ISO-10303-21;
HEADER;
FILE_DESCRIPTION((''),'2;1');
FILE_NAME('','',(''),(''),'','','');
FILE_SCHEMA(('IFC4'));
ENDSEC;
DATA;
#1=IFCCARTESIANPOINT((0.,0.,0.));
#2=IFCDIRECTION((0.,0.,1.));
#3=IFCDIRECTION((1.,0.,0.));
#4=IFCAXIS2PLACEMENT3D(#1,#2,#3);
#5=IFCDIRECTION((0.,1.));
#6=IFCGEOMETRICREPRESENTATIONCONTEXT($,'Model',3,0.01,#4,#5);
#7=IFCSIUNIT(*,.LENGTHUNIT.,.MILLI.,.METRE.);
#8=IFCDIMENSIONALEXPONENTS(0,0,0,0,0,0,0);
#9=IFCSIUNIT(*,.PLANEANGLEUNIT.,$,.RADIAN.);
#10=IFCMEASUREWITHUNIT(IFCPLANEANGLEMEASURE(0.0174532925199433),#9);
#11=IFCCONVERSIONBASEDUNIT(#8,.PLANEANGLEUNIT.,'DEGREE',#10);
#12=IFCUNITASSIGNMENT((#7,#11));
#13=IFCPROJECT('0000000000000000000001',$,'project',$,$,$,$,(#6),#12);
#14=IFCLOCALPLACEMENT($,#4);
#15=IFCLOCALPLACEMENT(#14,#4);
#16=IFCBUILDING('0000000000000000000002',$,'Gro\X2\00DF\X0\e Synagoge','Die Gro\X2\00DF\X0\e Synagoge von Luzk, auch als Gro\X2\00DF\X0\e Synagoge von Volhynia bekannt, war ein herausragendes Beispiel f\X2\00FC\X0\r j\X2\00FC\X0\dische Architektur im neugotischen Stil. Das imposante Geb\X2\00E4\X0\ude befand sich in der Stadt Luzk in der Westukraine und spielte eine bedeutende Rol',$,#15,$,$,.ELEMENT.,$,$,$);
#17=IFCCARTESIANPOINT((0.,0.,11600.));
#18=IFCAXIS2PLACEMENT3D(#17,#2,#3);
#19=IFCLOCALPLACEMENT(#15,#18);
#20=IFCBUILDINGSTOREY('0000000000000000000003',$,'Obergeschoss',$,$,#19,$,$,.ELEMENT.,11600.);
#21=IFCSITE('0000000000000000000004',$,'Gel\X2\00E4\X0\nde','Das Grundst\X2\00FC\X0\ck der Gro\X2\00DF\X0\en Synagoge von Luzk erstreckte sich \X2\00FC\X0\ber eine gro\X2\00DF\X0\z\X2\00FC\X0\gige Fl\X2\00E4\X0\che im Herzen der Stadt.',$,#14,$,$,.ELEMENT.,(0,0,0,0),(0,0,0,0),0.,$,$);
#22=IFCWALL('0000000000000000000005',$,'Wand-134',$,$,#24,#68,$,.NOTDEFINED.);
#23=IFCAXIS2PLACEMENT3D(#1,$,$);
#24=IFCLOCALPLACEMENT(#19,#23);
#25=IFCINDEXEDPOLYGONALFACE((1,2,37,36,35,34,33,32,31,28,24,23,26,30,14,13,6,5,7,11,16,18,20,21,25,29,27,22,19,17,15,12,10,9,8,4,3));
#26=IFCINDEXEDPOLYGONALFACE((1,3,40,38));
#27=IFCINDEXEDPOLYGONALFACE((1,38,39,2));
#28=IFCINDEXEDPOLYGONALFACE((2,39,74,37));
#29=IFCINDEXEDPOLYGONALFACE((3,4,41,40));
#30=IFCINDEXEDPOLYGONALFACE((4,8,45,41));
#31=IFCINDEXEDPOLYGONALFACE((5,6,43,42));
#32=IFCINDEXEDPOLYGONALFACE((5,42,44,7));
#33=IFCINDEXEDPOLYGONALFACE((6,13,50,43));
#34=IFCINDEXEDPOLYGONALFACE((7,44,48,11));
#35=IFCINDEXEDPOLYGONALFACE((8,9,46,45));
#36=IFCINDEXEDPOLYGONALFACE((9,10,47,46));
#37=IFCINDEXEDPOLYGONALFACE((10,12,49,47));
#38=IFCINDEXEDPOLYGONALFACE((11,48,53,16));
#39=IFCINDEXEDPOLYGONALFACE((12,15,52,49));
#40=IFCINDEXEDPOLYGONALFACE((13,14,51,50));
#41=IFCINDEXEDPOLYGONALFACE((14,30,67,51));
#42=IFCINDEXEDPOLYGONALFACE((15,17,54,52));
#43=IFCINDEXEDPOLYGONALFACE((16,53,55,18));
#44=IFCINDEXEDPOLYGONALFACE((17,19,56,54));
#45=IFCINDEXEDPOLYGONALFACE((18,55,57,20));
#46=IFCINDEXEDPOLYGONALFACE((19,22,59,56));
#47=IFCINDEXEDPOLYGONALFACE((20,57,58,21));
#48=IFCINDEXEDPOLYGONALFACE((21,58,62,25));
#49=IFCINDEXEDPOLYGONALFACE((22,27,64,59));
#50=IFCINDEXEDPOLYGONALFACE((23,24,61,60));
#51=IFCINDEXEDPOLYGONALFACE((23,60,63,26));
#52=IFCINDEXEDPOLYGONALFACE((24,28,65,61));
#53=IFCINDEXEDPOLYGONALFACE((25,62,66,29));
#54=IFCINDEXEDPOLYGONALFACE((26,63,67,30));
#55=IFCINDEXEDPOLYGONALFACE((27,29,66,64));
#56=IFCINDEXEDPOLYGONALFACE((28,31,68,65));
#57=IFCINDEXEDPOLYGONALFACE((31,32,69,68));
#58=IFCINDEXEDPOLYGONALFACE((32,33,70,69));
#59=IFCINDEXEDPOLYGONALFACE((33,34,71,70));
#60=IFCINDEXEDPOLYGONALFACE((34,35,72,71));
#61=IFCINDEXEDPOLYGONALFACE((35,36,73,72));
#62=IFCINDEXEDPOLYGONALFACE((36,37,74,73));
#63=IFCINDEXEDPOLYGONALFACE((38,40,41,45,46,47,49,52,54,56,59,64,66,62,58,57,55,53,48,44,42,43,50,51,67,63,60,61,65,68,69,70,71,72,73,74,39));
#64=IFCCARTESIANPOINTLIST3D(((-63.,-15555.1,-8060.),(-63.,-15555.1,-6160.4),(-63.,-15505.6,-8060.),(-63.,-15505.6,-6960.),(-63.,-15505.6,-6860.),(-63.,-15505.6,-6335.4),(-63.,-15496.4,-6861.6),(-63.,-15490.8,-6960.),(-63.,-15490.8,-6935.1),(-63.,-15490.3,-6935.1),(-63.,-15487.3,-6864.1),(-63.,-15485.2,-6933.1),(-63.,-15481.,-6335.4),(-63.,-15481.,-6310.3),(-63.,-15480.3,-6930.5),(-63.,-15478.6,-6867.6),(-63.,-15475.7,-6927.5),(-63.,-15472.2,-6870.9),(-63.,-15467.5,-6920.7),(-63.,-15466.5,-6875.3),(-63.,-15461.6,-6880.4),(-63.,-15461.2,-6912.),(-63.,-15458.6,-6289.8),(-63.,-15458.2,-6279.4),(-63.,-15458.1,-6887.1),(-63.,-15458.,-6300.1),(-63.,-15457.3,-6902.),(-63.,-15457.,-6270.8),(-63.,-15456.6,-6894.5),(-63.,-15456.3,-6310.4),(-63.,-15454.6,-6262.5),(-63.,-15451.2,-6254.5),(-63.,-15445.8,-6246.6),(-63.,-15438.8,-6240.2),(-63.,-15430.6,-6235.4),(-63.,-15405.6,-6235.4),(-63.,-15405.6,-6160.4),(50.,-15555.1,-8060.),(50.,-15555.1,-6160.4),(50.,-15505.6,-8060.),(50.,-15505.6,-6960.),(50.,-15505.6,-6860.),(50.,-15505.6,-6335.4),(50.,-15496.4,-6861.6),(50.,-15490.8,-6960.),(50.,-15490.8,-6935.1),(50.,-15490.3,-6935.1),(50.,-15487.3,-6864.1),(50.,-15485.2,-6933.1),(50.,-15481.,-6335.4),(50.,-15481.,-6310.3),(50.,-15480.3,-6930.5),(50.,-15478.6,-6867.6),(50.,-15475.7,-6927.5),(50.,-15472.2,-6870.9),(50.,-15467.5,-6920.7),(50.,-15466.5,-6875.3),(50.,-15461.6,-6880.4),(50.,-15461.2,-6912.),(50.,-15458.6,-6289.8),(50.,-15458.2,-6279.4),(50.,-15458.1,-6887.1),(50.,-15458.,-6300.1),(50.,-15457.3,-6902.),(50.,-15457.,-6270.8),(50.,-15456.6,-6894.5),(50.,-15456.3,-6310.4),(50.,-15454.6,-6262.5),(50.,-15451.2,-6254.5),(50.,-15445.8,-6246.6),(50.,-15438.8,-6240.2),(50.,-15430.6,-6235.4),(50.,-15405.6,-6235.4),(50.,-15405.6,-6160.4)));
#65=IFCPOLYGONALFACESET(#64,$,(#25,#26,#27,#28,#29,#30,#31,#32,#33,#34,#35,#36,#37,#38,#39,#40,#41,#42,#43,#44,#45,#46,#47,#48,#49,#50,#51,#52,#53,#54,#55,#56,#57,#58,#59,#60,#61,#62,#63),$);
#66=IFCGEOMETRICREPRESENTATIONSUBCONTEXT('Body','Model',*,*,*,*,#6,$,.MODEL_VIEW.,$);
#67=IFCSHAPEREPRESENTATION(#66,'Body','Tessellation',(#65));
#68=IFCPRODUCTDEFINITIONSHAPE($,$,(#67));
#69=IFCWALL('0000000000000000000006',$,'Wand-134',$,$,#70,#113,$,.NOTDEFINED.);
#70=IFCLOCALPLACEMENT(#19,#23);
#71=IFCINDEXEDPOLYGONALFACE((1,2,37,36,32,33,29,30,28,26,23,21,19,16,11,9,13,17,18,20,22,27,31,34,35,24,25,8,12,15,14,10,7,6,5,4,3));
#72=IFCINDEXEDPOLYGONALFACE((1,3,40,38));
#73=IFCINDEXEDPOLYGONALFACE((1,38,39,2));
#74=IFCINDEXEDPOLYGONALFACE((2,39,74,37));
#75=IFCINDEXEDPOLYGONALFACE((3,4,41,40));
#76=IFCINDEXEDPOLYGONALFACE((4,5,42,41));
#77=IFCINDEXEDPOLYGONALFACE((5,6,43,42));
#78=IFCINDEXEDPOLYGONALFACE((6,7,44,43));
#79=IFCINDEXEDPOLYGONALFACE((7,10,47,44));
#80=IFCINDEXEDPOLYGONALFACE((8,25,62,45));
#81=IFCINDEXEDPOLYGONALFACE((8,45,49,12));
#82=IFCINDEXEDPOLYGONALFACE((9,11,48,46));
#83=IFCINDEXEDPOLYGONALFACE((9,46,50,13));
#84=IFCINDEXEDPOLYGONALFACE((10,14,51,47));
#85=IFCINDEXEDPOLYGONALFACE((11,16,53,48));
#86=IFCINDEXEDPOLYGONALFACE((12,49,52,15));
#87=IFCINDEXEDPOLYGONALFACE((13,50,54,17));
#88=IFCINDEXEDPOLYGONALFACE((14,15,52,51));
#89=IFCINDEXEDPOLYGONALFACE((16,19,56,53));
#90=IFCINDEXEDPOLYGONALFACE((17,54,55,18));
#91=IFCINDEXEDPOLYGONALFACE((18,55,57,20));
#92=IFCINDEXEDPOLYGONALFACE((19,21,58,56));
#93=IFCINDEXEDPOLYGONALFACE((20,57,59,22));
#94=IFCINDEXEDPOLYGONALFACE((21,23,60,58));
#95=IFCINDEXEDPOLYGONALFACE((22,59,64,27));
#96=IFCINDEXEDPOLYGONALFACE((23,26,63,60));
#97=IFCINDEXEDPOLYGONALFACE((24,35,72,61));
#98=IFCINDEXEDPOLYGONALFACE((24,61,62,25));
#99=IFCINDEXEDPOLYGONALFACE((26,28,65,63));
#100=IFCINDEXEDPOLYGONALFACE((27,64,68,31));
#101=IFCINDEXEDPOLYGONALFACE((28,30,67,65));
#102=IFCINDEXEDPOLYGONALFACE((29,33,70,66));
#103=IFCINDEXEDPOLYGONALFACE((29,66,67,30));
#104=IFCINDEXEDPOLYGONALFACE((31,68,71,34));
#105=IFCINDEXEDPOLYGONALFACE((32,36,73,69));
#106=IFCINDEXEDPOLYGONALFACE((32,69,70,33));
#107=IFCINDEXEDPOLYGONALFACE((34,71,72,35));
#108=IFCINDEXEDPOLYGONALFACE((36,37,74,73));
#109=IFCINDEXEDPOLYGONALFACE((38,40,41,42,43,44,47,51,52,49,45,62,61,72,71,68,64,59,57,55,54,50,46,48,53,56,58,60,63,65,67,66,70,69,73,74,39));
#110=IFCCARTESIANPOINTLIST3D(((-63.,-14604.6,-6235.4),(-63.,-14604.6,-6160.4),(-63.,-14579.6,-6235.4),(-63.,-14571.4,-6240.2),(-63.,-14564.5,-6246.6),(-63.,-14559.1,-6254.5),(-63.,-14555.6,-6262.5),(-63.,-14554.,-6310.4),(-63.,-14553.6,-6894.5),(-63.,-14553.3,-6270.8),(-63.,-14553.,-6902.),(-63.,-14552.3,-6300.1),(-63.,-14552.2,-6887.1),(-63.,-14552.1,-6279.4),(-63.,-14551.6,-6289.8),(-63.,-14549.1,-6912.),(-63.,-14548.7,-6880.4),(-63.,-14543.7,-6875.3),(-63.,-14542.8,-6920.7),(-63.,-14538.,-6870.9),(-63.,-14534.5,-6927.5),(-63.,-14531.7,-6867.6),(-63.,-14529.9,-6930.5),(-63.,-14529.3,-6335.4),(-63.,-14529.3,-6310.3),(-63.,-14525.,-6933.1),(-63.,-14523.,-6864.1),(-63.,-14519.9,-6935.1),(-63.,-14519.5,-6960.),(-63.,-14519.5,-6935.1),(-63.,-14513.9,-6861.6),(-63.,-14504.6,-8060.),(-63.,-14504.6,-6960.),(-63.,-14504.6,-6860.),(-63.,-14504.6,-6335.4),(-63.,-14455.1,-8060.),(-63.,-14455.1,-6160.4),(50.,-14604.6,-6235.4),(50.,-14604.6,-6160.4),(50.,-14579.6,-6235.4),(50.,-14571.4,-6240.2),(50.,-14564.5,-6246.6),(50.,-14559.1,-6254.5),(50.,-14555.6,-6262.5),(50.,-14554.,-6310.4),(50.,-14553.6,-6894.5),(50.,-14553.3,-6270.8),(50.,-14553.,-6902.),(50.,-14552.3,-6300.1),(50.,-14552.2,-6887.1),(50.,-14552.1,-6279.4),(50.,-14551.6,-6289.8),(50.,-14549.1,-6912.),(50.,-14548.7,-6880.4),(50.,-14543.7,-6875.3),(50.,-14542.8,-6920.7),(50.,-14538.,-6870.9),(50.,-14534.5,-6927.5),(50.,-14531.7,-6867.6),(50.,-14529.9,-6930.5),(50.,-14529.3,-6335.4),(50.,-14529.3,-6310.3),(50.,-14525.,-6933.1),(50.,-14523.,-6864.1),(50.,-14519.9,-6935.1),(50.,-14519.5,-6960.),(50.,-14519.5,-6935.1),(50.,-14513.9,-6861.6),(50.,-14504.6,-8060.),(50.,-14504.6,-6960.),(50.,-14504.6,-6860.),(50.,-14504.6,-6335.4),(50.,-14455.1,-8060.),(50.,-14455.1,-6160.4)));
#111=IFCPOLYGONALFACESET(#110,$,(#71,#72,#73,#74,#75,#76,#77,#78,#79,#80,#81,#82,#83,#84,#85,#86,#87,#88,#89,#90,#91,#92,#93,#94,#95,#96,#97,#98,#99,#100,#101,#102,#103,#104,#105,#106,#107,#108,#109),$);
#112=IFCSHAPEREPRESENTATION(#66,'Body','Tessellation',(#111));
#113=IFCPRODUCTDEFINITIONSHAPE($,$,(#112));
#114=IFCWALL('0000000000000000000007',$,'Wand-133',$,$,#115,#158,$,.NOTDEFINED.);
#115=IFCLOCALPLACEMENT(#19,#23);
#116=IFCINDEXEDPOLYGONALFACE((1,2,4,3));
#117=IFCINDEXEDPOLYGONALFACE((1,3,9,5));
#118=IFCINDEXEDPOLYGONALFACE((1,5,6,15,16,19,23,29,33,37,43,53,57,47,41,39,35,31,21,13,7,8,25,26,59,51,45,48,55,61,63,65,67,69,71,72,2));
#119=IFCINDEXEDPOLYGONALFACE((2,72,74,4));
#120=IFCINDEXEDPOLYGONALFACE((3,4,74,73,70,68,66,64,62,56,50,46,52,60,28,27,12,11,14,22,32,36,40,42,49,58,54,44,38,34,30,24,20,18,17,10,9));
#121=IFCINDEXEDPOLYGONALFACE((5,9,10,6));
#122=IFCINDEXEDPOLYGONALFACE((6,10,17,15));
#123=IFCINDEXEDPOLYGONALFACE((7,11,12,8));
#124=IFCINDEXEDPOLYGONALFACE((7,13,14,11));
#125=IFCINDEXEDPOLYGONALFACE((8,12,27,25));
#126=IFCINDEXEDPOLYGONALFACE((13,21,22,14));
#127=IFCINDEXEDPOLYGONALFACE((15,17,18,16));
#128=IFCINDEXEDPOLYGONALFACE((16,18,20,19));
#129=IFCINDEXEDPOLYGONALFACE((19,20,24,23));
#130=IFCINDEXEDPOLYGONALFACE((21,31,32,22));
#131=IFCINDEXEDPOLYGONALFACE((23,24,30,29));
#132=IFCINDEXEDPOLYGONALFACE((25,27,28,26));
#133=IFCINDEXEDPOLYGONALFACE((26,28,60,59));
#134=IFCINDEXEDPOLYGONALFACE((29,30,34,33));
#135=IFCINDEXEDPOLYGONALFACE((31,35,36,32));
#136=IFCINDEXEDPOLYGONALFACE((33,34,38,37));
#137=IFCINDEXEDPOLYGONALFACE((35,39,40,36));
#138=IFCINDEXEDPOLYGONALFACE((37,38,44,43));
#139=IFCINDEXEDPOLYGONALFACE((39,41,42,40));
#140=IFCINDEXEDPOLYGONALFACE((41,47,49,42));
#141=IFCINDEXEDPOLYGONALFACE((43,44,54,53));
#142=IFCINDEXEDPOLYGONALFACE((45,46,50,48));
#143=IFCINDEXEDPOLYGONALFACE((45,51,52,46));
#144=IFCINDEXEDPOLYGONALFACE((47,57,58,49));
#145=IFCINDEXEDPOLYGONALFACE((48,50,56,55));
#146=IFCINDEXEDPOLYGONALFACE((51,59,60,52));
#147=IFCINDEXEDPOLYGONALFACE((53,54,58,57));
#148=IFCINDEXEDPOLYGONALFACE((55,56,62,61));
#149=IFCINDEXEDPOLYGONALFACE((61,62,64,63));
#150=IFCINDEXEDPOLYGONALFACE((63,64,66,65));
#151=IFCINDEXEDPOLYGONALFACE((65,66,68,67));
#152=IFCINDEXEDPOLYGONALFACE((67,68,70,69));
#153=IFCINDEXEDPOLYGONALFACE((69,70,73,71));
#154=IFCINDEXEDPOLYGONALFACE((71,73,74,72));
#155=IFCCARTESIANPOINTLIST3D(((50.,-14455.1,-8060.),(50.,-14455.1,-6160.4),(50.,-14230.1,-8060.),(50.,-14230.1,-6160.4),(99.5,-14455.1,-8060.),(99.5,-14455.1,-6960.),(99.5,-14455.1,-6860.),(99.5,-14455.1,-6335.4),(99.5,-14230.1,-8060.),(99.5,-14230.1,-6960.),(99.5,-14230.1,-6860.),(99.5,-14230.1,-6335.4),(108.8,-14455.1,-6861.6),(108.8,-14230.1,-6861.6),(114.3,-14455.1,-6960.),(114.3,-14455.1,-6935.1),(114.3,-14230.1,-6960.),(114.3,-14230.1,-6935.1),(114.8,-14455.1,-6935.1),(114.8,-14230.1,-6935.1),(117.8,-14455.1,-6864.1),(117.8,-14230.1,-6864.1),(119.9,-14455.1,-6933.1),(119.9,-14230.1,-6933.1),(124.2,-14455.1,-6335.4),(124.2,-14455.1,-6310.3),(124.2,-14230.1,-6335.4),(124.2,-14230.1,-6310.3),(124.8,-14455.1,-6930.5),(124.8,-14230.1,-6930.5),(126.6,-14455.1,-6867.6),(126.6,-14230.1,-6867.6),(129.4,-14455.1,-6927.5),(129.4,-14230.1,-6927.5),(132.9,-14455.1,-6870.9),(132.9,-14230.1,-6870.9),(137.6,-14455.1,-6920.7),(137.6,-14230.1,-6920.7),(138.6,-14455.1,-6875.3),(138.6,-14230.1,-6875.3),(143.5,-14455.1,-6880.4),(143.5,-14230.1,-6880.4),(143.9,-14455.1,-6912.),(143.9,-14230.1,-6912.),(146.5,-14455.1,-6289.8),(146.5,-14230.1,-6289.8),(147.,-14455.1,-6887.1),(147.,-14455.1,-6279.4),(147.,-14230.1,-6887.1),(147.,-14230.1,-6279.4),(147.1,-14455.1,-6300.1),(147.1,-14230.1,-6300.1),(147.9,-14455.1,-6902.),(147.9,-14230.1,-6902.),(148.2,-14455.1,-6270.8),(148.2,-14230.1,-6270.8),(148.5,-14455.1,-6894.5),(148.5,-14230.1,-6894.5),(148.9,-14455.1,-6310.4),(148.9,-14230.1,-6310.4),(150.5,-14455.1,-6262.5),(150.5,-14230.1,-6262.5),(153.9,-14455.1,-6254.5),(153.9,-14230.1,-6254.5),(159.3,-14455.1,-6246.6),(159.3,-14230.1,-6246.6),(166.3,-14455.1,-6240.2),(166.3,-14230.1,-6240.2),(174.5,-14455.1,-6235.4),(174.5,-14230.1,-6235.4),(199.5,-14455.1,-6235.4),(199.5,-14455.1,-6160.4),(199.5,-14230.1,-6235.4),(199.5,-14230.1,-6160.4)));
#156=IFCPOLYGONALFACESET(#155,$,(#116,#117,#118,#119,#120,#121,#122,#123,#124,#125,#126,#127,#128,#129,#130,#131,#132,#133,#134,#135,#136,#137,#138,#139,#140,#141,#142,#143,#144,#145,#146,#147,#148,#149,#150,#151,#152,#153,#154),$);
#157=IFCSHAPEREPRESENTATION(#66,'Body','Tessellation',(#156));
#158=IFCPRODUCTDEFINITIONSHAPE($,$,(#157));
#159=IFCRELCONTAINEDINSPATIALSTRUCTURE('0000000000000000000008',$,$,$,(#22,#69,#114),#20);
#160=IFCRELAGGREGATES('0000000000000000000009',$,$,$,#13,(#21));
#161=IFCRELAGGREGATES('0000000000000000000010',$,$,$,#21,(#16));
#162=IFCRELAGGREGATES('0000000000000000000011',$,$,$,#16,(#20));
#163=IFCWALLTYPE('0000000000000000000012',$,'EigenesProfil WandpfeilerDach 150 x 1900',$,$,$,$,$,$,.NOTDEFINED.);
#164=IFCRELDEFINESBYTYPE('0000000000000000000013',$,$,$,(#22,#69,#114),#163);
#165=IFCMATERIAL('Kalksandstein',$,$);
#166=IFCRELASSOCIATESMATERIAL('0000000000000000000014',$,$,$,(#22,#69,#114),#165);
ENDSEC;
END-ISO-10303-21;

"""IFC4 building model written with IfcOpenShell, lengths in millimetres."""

from ifc_helpers import new_model, entity, si_unit, converted_unit, direction, frame, origin_with_axes, place, context, subcontext, project, spatial, line, arc, indexed_curve, outline, extrude, material, material_profile, profile_set, type_object, element, save


model = new_model("IFC4")

# Units and contexts
model_context = context("Model", 3, precision=0.01, world=origin_with_axes(), true_north=direction((0.0, 1.0)))
body_context = subcontext(model_context, "Body", "Model", "MODEL_VIEW")
ifc_project = project(units=[si_unit("LENGTHUNIT", "METRE", prefix="MILLI"), converted_unit("PLANEANGLEUNIT", "DEGREE", entity("IfcPlaneAngleMeasure", 0.0174532925199433), si_unit("PLANEANGLEUNIT", "RADIAN"), dimensions=[0, 0, 0, 0, 0, 0, 0])], contexts=[model_context])

# Site, building, storey
site_placement = place(None, origin_with_axes())
site = spatial("IfcSite", under=ifc_project, at=site_placement, Name="Gelände", Description="Das Grundstück der Großen Synagoge von Luzk erstreckte sich über eine großzügige Fläche im Herzen der Stadt.", CompositionType="ELEMENT", RefLatitude=(0, 0, 0, 0), RefLongitude=(0, 0, 0, 0), RefElevation=0.0)
building_placement = place(site_placement, origin_with_axes())
building = spatial("IfcBuilding", under=site, at=building_placement, Name="Große Synagoge", Description="Die Große Synagoge von Luzk, auch als Große Synagoge von Volhynia bekannt, war ein herausragendes Beispiel für jüdische Architektur im neugotischen Stil. Das imposante Gebäude befand sich in der Stadt Luzk in der Westukraine und spielte eine bedeutende Rol", CompositionType="ELEMENT")
storey_placement = place(building_placement, frame((0.0, 0.0, 11600.0), z_axis=(0.0, 0.0, 1.0), x_axis=(1.0, 0.0, 0.0)))
storey = spatial("IfcBuildingStorey", under=building, at=storey_placement, Name="Obergeschoss", CompositionType="ELEMENT", Elevation=11600.0)

# Walls
ifc_material_1 = material(Name="Kalksandstein")
ifc_material_profile = material_profile(ifc_material_1, outline(indexed_curve([(74.2, 1749.6), (98.9, 1749.6), (96.7, 1765.0), (97.0, 1780.5), (99.2, 1793.4), (103.9, 1805.5), (112.6, 1816.7), (124.5, 1824.6), (149.5, 1824.6), (149.5, 1899.6), (0.0, 1899.6), (0.0, 0.0), (49.5, 0.0), (49.5, 1100.0), (64.3, 1100.0), (64.3, 1124.9), (64.8, 1124.9), (72.4, 1128.1), (79.4, 1132.4), (91.1, 1143.4), (97.9, 1157.9), (98.0, 1169.2), (93.5, 1179.5), (85.8, 1187.0), (76.6, 1192.3), (63.3, 1197.2), (49.5, 1200.0), (49.5, 1724.6), (74.2, 1724.6)], segments=[line(1, 2), arc(2, 3, 4), arc(4, 5, 6), arc(6, 7, 8), line(8, 9, 10, 11, 12, 13, 14, 15, 16, 17), arc(17, 18, 19), arc(19, 20, 21), arc(21, 22, 23), arc(23, 24, 25), arc(25, 26, 27), line(27, 28, 29, 1)])), Name="Kalksandstein")
ifc_profile_set = profile_set([ifc_material_profile], Name="EigenesProfil WandpfeilerDach")
wall_type_1 = type_object("IfcWallType", Name="EigenesProfil WandpfeilerDach 150 x 1900", PredefinedType="NOTDEFINED")
wall_1_placement = place(storey_placement, frame((50.0, -15555.1, -8060.0), z_axis=(0.0, 0.0, 1.0), x_axis=(-1.0, 0.0, 0.0)))
element("IfcWall", 1, at=wall_1_placement, inside=storey, type_object=wall_type_1, material=ifc_profile_set, Name="Wand-134", PredefinedType="NOTDEFINED", context=body_context, shape_type="SweptSolid", body=[
    extrude(outline(indexed_curve([(74.2, 1749.6), (98.9, 1749.6), (96.7, 1765.0), (97.0, 1780.5), (99.2, 1793.4), (103.9, 1805.5), (112.6, 1816.7), (124.5, 1824.6), (149.5, 1824.6), (149.5, 1899.6), (0.0, 1899.6), (0.0, 0.0), (49.5, 0.0), (49.5, 1100.0), (64.3, 1100.0), (64.3, 1124.9), (64.8, 1124.9), (72.4, 1128.1), (79.4, 1132.4), (91.1, 1143.4), (97.9, 1157.9), (98.0, 1169.2), (93.5, 1179.5), (85.8, 1187.0), (76.6, 1192.3), (63.3, 1197.2), (49.5, 1200.0), (49.5, 1724.6), (74.2, 1724.6)], segments=[line(1, 2), arc(2, 3, 4), arc(4, 5, 6), arc(6, 7, 8), line(8, 9, 10, 11, 12, 13, 14, 15, 16, 17), arc(17, 18, 19), arc(19, 20, 21), arc(21, 22, 23), arc(23, 24, 25), arc(25, 26, 27), line(27, 28, 29, 1)])), frame((0.0, 0.0, 0.0), z_axis=(-1.0, 0.0, 0.0), x_axis=(0.0, -1.0, 0.0)), (0.0, 0.0, -1.0), 113.0),
])
wall_2_placement = place(storey_placement, frame((50.0, -14455.1, -8060.0), z_axis=(0.0, 0.0, 1.0), x_axis=(-1.0, 0.0, 0.0)))
element("IfcWall", 2, at=wall_2_placement, inside=storey, type_object=wall_type_1, material=ifc_profile_set, Name="Wand-134", PredefinedType="NOTDEFINED", context=body_context, shape_type="SweptSolid", body=[
    extrude(outline(indexed_curve([(74.2, 1749.6), (98.9, 1749.6), (96.7, 1765.0), (97.0, 1780.5), (99.2, 1793.4), (103.9, 1805.5), (112.6, 1816.7), (124.5, 1824.6), (149.5, 1824.6), (149.5, 1899.6), (0.0, 1899.6), (0.0, 0.0), (49.5, 0.0), (49.5, 1100.0), (64.3, 1100.0), (64.3, 1124.9), (64.8, 1124.9), (72.4, 1128.1), (79.4, 1132.4), (91.1, 1143.4), (97.9, 1157.9), (98.0, 1169.2), (93.5, 1179.5), (85.8, 1187.0), (76.6, 1192.3), (63.3, 1197.2), (49.5, 1200.0), (49.5, 1724.6), (74.2, 1724.6)], segments=[line(1, 2), arc(2, 3, 4), arc(4, 5, 6), arc(6, 7, 8), line(8, 9, 10, 11, 12, 13, 14, 15, 16, 17), arc(17, 18, 19), arc(19, 20, 21), arc(21, 22, 23), arc(23, 24, 25), arc(25, 26, 27), line(27, 28, 29, 1)])), frame((0.0, 0.0, 0.0), z_axis=(1.0, 0.0, 0.0), x_axis=(0.0, 1.0, 0.0)), (0.0, 0.0, 1.0), 113.0),
])
wall_3_placement = place(storey_placement, frame((50.0, -14230.1, -8060.0), z_axis=(0.0, 0.0, 1.0), x_axis=(0.0, -1.0, 0.0)))
element("IfcWall", 3, at=wall_3_placement, inside=storey, type_object=wall_type_1, material=ifc_profile_set, Name="Wand-133", PredefinedType="NOTDEFINED", context=body_context, shape_type="SweptSolid", body=[
    extrude(outline(indexed_curve([(74.2, 1749.6), (98.9, 1749.6), (96.7, 1765.0), (97.0, 1780.5), (99.2, 1793.4), (103.9, 1805.5), (112.6, 1816.7), (124.5, 1824.6), (149.5, 1824.6), (149.5, 1899.6), (0.0, 1899.6), (0.0, 0.0), (49.5, 0.0), (49.5, 1100.0), (64.3, 1100.0), (64.3, 1124.9), (64.8, 1124.9), (72.4, 1128.1), (79.4, 1132.4), (91.1, 1143.4), (97.9, 1157.9), (98.0, 1169.2), (93.5, 1179.5), (85.8, 1187.0), (76.6, 1192.3), (63.3, 1197.2), (49.5, 1200.0), (49.5, 1724.6), (74.2, 1724.6)], segments=[line(1, 2), arc(2, 3, 4), arc(4, 5, 6), arc(6, 7, 8), line(8, 9, 10, 11, 12, 13, 14, 15, 16, 17), arc(17, 18, 19), arc(19, 20, 21), arc(21, 22, 23), arc(23, 24, 25), arc(25, 26, 27), line(27, 28, 29, 1)])), frame((0.0, 0.0, 0.0), z_axis=(1.0, 0.0, 0.0), x_axis=(0.0, 1.0, 0.0)), (0.0, 0.0, 1.0), 225.0),
])

save(model, "model.ifc")
